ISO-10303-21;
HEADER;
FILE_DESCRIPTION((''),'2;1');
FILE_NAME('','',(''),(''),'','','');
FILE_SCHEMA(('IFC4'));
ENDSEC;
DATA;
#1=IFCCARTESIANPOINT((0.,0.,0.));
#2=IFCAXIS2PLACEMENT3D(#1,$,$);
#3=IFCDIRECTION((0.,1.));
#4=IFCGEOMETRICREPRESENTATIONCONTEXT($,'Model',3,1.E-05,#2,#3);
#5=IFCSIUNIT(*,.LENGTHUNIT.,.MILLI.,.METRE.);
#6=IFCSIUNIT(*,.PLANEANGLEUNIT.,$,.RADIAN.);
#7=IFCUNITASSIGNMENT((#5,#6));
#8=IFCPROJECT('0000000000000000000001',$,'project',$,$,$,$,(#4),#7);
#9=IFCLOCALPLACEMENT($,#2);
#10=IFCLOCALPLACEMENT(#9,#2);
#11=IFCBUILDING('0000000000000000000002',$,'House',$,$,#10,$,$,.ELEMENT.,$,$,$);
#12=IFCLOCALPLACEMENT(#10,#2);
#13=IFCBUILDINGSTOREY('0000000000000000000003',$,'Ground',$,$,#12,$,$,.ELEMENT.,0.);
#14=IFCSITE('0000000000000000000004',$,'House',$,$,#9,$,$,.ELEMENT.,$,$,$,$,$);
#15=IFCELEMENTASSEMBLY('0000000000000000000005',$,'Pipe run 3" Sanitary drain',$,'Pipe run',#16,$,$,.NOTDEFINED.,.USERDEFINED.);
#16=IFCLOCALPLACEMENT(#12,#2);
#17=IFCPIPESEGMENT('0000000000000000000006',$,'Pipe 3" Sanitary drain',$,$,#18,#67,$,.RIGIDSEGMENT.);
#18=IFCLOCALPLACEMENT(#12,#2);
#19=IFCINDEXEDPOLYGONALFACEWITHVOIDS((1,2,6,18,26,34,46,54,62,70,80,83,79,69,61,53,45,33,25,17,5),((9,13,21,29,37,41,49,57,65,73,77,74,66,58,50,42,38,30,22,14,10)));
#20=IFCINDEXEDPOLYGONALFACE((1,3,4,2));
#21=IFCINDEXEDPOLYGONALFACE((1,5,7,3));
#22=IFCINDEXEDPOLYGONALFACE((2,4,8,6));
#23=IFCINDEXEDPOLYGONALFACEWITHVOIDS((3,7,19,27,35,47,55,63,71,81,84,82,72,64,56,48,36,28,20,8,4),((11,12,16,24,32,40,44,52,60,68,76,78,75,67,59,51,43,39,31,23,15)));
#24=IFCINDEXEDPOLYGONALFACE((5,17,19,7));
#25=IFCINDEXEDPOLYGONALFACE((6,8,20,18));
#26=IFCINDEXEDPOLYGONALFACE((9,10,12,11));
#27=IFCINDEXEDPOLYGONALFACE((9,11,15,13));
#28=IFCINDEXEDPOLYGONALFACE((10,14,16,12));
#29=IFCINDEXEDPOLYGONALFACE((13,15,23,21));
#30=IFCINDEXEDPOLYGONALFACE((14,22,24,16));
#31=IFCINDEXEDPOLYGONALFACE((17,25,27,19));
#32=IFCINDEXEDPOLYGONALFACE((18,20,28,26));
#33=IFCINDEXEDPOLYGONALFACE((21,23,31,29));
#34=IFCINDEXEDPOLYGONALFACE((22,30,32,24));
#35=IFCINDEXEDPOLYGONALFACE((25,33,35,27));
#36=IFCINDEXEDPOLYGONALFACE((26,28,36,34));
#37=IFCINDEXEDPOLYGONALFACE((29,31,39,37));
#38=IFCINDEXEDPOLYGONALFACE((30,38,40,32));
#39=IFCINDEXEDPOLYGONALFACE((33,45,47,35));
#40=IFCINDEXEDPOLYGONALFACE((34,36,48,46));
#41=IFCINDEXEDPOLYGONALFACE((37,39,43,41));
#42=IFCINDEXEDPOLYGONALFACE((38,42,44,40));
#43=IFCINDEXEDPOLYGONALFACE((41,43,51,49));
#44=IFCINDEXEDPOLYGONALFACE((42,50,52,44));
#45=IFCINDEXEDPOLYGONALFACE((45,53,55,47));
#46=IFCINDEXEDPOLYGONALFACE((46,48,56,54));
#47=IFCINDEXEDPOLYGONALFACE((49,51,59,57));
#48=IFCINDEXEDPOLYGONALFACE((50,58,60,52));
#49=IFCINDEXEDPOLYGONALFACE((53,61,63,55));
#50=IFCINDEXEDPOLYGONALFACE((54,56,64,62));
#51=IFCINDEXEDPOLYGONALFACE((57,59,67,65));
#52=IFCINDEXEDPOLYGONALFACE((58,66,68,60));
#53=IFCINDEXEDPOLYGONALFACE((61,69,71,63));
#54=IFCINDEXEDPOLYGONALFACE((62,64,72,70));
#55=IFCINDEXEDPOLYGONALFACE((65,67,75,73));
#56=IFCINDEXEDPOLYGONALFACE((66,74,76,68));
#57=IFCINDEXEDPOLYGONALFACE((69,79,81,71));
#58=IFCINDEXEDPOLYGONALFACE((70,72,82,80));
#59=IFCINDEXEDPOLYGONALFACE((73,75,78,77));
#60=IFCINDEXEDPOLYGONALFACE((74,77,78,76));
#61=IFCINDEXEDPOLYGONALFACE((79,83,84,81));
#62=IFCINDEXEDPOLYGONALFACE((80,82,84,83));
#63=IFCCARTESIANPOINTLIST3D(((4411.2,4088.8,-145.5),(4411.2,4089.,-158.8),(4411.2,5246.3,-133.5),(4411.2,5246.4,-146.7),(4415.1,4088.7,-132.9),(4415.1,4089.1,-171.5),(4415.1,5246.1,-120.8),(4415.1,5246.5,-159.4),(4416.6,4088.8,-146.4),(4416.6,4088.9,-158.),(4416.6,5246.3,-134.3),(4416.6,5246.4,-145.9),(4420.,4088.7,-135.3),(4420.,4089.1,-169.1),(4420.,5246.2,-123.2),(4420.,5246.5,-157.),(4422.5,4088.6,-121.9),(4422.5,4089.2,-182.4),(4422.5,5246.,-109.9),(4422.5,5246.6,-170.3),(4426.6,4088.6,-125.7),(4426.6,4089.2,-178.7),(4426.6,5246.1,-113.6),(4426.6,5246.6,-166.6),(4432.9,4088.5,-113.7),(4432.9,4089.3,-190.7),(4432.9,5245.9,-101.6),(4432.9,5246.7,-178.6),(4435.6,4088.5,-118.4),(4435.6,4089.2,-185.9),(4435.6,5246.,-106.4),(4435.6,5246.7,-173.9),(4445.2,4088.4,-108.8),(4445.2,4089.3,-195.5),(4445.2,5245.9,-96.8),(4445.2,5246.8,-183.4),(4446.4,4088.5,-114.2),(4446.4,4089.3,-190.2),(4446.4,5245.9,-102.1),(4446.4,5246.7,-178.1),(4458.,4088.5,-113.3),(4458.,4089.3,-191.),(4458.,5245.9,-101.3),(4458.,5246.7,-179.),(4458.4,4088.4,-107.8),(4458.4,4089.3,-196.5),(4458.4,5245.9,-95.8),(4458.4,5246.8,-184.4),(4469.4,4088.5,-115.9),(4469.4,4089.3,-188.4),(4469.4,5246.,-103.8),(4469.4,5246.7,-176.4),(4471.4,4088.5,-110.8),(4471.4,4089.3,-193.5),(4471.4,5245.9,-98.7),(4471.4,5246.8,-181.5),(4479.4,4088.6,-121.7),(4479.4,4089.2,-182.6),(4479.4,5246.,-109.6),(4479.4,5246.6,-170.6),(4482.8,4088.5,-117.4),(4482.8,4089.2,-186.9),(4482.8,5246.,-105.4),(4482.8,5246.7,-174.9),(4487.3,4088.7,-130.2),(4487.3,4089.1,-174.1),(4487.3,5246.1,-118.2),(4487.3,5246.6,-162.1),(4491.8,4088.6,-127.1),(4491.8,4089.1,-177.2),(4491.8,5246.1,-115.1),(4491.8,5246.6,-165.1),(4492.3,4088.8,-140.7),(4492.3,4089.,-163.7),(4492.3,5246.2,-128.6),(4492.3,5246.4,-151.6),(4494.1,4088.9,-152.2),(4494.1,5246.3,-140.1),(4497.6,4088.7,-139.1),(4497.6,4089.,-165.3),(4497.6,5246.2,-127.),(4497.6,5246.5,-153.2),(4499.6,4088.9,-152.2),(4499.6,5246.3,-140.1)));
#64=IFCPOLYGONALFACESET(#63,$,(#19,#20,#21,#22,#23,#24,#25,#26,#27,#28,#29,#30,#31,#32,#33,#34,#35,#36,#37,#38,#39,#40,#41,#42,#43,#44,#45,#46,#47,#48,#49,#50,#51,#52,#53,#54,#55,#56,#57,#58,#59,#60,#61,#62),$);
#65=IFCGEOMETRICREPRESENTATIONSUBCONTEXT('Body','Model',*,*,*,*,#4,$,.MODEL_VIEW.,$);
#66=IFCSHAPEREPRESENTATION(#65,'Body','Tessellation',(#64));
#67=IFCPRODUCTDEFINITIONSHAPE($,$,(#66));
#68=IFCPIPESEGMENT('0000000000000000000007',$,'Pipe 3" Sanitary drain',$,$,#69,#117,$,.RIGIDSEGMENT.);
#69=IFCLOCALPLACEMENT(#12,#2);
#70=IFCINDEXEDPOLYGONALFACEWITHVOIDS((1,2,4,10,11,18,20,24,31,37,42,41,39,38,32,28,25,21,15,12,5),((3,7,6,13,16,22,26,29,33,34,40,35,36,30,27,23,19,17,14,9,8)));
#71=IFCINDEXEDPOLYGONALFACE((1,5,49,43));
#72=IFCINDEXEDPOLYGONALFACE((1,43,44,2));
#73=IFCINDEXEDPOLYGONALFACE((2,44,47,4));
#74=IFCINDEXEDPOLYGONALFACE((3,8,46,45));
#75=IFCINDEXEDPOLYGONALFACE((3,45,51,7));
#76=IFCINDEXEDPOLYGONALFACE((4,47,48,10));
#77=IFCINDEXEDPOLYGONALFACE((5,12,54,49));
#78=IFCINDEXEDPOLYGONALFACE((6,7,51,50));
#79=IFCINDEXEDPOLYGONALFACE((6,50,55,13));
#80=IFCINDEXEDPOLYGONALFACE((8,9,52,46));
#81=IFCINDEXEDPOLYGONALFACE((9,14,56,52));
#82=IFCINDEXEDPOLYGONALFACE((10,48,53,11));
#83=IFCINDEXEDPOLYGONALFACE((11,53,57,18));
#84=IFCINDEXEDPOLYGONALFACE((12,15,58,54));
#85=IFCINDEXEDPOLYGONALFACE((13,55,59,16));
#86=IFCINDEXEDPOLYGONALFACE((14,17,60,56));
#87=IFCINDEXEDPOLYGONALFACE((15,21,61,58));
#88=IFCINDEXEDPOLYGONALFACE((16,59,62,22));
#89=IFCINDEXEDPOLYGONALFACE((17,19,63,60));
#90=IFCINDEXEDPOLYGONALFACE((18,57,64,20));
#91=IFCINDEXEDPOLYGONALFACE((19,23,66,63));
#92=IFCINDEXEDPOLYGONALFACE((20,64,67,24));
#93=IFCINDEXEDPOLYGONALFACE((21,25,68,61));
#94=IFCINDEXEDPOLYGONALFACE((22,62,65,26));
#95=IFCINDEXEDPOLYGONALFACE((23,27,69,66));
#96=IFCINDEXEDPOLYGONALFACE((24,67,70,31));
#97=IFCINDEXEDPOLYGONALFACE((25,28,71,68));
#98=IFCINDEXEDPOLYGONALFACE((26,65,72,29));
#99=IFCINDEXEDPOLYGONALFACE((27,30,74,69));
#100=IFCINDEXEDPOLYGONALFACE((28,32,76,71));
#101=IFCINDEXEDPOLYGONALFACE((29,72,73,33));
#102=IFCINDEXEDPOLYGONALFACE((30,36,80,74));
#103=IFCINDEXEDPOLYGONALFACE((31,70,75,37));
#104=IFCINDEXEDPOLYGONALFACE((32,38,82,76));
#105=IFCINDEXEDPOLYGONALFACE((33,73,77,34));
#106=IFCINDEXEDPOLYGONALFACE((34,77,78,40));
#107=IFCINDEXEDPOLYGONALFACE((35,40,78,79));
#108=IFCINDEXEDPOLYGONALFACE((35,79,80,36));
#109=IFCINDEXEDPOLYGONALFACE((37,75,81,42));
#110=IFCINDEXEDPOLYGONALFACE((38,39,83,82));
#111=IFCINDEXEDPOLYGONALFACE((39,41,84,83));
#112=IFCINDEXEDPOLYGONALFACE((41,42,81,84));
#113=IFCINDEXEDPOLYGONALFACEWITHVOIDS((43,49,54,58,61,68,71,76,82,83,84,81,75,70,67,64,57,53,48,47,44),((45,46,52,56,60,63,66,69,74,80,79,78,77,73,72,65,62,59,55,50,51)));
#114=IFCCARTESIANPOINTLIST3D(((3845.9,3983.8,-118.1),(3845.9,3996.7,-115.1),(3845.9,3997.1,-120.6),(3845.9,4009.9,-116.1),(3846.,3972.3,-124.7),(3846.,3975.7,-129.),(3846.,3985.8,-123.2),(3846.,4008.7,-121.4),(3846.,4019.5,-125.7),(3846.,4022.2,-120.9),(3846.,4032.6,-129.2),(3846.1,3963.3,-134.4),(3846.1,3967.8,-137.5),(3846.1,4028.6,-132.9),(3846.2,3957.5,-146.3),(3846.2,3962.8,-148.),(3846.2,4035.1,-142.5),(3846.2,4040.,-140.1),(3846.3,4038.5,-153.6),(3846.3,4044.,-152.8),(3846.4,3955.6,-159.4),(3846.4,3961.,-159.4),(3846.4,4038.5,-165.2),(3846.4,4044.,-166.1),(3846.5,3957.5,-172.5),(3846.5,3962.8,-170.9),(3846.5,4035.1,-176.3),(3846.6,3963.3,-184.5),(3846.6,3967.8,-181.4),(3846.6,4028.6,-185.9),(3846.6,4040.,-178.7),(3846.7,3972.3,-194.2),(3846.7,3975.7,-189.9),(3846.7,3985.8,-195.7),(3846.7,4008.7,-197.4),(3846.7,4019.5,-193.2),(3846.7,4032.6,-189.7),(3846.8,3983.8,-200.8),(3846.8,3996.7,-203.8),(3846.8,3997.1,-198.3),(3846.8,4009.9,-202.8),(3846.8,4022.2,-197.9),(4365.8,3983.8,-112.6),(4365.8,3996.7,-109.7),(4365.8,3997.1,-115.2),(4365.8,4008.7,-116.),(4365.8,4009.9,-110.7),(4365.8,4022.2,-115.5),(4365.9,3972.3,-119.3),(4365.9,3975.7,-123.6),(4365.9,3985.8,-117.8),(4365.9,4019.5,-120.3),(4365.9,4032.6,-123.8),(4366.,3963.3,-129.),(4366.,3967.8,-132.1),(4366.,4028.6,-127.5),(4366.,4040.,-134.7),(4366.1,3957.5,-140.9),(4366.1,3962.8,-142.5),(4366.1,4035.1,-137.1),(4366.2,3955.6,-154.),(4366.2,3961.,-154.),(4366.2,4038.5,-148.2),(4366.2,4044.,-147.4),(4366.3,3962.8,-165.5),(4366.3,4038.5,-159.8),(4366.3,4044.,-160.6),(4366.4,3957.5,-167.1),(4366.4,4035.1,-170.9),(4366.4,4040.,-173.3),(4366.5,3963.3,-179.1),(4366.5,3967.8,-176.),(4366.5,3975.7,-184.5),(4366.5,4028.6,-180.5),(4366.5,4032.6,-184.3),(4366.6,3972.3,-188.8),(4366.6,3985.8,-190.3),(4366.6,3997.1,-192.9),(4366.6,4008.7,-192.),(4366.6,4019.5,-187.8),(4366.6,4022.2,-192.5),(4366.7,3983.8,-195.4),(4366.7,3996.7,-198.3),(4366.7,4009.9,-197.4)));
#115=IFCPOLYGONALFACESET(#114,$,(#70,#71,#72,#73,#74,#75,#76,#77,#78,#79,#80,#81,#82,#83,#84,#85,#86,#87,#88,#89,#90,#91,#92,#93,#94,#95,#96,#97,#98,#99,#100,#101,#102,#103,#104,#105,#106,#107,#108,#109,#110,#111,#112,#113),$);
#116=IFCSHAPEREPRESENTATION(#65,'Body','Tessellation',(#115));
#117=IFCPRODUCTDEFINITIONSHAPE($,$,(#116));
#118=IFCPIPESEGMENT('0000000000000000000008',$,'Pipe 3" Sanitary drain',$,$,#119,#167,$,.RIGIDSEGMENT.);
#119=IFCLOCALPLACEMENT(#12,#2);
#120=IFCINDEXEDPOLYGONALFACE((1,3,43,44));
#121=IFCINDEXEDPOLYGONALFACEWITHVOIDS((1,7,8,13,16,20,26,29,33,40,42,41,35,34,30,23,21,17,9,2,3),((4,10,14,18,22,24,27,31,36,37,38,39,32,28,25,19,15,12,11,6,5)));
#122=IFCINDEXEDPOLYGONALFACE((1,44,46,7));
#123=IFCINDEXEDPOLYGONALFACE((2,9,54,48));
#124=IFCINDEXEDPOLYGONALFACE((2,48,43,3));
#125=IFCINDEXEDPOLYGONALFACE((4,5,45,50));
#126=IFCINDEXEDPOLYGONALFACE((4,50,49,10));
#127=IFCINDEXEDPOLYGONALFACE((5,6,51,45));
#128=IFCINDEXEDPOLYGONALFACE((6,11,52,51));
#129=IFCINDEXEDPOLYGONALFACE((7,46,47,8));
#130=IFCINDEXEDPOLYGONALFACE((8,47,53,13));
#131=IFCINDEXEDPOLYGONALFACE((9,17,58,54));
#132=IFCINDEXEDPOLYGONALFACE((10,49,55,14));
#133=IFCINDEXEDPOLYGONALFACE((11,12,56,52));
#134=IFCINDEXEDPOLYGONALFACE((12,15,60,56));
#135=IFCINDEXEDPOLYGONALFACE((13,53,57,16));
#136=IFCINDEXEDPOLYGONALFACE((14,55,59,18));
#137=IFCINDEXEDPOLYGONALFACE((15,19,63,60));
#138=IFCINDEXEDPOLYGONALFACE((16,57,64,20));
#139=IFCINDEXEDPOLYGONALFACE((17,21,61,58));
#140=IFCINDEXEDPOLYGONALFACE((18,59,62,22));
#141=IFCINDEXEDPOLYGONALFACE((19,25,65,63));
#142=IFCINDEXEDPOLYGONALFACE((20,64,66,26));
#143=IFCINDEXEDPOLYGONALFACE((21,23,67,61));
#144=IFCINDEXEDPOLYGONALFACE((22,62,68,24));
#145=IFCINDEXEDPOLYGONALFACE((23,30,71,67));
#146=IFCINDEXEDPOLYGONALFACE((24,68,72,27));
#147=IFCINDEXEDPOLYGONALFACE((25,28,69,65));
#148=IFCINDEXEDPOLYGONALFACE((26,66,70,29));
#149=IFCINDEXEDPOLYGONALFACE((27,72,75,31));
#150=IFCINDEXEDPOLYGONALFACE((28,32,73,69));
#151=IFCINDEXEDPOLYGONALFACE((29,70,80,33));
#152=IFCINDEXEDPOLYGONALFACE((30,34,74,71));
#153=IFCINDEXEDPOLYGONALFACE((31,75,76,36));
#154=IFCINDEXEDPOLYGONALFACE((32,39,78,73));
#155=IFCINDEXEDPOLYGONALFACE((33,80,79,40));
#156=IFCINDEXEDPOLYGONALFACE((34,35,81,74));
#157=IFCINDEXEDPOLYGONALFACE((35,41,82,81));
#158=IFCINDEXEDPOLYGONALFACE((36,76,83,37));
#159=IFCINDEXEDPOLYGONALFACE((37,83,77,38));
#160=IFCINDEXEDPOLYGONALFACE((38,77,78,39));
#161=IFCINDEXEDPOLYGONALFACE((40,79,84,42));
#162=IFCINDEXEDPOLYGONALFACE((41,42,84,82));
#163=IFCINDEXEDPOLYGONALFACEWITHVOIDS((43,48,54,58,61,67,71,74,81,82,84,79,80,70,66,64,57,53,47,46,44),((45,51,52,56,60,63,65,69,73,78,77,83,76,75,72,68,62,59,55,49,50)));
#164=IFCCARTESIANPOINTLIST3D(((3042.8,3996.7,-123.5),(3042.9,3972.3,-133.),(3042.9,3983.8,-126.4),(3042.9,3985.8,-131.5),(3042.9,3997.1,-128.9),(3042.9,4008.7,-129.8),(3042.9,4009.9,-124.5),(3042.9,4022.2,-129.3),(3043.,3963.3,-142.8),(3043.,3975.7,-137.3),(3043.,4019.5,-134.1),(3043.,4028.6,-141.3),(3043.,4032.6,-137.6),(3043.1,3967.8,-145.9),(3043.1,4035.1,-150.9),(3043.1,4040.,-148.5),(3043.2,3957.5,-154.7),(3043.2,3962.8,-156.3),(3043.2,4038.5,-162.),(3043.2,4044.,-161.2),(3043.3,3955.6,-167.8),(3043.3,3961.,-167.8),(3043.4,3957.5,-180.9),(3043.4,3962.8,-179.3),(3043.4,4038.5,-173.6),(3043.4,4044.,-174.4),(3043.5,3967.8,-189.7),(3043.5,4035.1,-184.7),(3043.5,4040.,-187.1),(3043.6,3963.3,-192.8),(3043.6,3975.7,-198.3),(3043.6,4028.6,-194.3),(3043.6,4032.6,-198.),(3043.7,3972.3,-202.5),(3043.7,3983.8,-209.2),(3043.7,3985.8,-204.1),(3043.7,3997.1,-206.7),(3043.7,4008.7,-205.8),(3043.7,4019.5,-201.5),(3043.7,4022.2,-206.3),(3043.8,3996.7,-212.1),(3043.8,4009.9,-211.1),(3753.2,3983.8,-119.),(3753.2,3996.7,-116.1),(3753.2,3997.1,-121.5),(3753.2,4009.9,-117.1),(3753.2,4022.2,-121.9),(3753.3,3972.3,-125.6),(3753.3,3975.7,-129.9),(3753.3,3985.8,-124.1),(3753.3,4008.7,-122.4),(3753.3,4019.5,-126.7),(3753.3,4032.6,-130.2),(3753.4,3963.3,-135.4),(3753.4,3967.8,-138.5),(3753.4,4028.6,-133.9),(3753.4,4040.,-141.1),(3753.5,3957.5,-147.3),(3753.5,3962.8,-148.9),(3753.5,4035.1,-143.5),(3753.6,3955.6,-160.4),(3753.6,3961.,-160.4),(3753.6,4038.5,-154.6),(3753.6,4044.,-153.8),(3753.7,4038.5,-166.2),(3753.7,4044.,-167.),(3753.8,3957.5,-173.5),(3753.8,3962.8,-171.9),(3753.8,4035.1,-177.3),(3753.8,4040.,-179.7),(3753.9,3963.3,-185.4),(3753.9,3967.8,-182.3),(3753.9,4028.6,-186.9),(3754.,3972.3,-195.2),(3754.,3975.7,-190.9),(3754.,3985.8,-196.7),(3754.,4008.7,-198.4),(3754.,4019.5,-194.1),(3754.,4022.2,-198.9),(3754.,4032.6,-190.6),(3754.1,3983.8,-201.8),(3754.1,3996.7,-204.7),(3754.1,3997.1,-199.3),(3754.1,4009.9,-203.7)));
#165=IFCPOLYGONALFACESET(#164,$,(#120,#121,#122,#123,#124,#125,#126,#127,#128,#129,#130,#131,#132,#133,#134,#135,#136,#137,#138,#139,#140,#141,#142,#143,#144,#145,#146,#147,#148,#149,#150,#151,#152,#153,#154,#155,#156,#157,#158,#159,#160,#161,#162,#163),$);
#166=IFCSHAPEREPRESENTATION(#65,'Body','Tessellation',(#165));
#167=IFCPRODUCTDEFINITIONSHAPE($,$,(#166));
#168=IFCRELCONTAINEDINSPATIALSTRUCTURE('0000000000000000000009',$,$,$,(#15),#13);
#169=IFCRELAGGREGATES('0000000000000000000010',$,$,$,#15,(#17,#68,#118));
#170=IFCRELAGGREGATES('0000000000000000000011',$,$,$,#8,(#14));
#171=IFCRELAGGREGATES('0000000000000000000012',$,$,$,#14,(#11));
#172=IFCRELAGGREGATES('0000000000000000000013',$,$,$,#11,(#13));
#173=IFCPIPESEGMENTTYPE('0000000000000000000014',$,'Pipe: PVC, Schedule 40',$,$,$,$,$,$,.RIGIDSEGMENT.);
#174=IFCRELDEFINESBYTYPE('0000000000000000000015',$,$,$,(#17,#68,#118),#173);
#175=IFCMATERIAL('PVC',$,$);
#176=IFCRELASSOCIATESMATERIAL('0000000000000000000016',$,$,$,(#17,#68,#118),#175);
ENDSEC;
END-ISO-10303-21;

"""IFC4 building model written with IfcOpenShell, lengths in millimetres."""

from ifc_helpers import new_model, si_unit, direction, frame, origin, origin_with_axes, origin_2d, place, context, subcontext, project, spatial, hollow_circle, extrude, material, type_object, element, aggregate, save


model = new_model("IFC4")

# Units and contexts
model_context = context("Model", 3, precision=1e-05, world=origin(), true_north=direction((0.0, 1.0)))
body_context = subcontext(model_context, "Body", "Model", "MODEL_VIEW")
ifc_project = project(units=[si_unit("LENGTHUNIT", "METRE", prefix="MILLI"), si_unit("PLANEANGLEUNIT", "RADIAN")], contexts=[model_context])

# Site, building, storey
site_placement = place(None, origin())
site = spatial("IfcSite", under=ifc_project, at=site_placement, Name="House", CompositionType="ELEMENT")
building_placement = place(site_placement, origin())
building = spatial("IfcBuilding", under=site, at=building_placement, Name="House", CompositionType="ELEMENT")
storey_placement = place(building_placement, origin())
storey = spatial("IfcBuildingStorey", under=building, at=storey_placement, Name="Ground", CompositionType="ELEMENT", Elevation=0.0)

# Element assembly, pipe segments
ifc_material = material(Name="PVC")
pipe_segment_type = type_object("IfcPipeSegmentType", Name="Pipe: PVC, Schedule 40", PredefinedType="RIGIDSEGMENT")
assembly_1_placement = place(storey_placement, origin_with_axes())
assembly_1 = element("IfcElementAssembly", 1, at=assembly_1_placement, inside=storey, Name="Pipe run 3\" Sanitary drain", ObjectType="Pipe run", AssemblyPlace="NOTDEFINED", PredefinedType="USERDEFINED")
pipe_segment_1_placement = place(storey_placement, origin_with_axes())
pipe_segment_1 = element("IfcPipeSegment", 2, at=pipe_segment_1_placement, type_object=pipe_segment_type, material=ifc_material, Name="Pipe 3\" Sanitary drain", PredefinedType="RIGIDSEGMENT", context=body_context, shape_type="SweptSolid", body=[
    extrude(hollow_circle(Radius=44.5, WallThickness=5.5, at=origin_2d()), frame((4455.1, 5246.3, -140.1), z_axis=(0.0, -0.999946, -0.010416), x_axis=(1.0, 0.0, 0.0)), (0.0, 0.0, 1.0), 1157.5),
])
pipe_segment_2_placement = place(storey_placement, origin_with_axes())
pipe_segment_2 = element("IfcPipeSegment", 3, at=pipe_segment_2_placement, type_object=pipe_segment_type, material=ifc_material, Name="Pipe 3\" Sanitary drain", PredefinedType="RIGIDSEGMENT", context=body_context, shape_type="SweptSolid", body=[
    extrude(hollow_circle(Radius=44.5, WallThickness=5.5, at=origin_2d()), frame((4366.2, 4000.0, -154.0), z_axis=(-0.999946, 0.0, -0.010416), x_axis=(0.0, -1.0, 0.0)), (0.0, 0.0, 1.0), 519.9),
])
pipe_segment_3_placement = place(storey_placement, origin_with_axes())
pipe_segment_3 = element("IfcPipeSegment", 4, at=pipe_segment_3_placement, type_object=pipe_segment_type, material=ifc_material, Name="Pipe 3\" Sanitary drain", PredefinedType="RIGIDSEGMENT", context=body_context, shape_type="SweptSolid", body=[
    extrude(hollow_circle(Radius=44.5, WallThickness=5.5, at=origin_2d()), frame((3753.6, 4000.0, -160.4), z_axis=(-0.999946, 0.0, -0.010416), x_axis=(0.0, -1.0, 0.0)), (0.0, 0.0, 1.0), 710.4),
])

aggregate(assembly_1, [pipe_segment_1, pipe_segment_2, pipe_segment_3])

save(model, "model.ifc")
